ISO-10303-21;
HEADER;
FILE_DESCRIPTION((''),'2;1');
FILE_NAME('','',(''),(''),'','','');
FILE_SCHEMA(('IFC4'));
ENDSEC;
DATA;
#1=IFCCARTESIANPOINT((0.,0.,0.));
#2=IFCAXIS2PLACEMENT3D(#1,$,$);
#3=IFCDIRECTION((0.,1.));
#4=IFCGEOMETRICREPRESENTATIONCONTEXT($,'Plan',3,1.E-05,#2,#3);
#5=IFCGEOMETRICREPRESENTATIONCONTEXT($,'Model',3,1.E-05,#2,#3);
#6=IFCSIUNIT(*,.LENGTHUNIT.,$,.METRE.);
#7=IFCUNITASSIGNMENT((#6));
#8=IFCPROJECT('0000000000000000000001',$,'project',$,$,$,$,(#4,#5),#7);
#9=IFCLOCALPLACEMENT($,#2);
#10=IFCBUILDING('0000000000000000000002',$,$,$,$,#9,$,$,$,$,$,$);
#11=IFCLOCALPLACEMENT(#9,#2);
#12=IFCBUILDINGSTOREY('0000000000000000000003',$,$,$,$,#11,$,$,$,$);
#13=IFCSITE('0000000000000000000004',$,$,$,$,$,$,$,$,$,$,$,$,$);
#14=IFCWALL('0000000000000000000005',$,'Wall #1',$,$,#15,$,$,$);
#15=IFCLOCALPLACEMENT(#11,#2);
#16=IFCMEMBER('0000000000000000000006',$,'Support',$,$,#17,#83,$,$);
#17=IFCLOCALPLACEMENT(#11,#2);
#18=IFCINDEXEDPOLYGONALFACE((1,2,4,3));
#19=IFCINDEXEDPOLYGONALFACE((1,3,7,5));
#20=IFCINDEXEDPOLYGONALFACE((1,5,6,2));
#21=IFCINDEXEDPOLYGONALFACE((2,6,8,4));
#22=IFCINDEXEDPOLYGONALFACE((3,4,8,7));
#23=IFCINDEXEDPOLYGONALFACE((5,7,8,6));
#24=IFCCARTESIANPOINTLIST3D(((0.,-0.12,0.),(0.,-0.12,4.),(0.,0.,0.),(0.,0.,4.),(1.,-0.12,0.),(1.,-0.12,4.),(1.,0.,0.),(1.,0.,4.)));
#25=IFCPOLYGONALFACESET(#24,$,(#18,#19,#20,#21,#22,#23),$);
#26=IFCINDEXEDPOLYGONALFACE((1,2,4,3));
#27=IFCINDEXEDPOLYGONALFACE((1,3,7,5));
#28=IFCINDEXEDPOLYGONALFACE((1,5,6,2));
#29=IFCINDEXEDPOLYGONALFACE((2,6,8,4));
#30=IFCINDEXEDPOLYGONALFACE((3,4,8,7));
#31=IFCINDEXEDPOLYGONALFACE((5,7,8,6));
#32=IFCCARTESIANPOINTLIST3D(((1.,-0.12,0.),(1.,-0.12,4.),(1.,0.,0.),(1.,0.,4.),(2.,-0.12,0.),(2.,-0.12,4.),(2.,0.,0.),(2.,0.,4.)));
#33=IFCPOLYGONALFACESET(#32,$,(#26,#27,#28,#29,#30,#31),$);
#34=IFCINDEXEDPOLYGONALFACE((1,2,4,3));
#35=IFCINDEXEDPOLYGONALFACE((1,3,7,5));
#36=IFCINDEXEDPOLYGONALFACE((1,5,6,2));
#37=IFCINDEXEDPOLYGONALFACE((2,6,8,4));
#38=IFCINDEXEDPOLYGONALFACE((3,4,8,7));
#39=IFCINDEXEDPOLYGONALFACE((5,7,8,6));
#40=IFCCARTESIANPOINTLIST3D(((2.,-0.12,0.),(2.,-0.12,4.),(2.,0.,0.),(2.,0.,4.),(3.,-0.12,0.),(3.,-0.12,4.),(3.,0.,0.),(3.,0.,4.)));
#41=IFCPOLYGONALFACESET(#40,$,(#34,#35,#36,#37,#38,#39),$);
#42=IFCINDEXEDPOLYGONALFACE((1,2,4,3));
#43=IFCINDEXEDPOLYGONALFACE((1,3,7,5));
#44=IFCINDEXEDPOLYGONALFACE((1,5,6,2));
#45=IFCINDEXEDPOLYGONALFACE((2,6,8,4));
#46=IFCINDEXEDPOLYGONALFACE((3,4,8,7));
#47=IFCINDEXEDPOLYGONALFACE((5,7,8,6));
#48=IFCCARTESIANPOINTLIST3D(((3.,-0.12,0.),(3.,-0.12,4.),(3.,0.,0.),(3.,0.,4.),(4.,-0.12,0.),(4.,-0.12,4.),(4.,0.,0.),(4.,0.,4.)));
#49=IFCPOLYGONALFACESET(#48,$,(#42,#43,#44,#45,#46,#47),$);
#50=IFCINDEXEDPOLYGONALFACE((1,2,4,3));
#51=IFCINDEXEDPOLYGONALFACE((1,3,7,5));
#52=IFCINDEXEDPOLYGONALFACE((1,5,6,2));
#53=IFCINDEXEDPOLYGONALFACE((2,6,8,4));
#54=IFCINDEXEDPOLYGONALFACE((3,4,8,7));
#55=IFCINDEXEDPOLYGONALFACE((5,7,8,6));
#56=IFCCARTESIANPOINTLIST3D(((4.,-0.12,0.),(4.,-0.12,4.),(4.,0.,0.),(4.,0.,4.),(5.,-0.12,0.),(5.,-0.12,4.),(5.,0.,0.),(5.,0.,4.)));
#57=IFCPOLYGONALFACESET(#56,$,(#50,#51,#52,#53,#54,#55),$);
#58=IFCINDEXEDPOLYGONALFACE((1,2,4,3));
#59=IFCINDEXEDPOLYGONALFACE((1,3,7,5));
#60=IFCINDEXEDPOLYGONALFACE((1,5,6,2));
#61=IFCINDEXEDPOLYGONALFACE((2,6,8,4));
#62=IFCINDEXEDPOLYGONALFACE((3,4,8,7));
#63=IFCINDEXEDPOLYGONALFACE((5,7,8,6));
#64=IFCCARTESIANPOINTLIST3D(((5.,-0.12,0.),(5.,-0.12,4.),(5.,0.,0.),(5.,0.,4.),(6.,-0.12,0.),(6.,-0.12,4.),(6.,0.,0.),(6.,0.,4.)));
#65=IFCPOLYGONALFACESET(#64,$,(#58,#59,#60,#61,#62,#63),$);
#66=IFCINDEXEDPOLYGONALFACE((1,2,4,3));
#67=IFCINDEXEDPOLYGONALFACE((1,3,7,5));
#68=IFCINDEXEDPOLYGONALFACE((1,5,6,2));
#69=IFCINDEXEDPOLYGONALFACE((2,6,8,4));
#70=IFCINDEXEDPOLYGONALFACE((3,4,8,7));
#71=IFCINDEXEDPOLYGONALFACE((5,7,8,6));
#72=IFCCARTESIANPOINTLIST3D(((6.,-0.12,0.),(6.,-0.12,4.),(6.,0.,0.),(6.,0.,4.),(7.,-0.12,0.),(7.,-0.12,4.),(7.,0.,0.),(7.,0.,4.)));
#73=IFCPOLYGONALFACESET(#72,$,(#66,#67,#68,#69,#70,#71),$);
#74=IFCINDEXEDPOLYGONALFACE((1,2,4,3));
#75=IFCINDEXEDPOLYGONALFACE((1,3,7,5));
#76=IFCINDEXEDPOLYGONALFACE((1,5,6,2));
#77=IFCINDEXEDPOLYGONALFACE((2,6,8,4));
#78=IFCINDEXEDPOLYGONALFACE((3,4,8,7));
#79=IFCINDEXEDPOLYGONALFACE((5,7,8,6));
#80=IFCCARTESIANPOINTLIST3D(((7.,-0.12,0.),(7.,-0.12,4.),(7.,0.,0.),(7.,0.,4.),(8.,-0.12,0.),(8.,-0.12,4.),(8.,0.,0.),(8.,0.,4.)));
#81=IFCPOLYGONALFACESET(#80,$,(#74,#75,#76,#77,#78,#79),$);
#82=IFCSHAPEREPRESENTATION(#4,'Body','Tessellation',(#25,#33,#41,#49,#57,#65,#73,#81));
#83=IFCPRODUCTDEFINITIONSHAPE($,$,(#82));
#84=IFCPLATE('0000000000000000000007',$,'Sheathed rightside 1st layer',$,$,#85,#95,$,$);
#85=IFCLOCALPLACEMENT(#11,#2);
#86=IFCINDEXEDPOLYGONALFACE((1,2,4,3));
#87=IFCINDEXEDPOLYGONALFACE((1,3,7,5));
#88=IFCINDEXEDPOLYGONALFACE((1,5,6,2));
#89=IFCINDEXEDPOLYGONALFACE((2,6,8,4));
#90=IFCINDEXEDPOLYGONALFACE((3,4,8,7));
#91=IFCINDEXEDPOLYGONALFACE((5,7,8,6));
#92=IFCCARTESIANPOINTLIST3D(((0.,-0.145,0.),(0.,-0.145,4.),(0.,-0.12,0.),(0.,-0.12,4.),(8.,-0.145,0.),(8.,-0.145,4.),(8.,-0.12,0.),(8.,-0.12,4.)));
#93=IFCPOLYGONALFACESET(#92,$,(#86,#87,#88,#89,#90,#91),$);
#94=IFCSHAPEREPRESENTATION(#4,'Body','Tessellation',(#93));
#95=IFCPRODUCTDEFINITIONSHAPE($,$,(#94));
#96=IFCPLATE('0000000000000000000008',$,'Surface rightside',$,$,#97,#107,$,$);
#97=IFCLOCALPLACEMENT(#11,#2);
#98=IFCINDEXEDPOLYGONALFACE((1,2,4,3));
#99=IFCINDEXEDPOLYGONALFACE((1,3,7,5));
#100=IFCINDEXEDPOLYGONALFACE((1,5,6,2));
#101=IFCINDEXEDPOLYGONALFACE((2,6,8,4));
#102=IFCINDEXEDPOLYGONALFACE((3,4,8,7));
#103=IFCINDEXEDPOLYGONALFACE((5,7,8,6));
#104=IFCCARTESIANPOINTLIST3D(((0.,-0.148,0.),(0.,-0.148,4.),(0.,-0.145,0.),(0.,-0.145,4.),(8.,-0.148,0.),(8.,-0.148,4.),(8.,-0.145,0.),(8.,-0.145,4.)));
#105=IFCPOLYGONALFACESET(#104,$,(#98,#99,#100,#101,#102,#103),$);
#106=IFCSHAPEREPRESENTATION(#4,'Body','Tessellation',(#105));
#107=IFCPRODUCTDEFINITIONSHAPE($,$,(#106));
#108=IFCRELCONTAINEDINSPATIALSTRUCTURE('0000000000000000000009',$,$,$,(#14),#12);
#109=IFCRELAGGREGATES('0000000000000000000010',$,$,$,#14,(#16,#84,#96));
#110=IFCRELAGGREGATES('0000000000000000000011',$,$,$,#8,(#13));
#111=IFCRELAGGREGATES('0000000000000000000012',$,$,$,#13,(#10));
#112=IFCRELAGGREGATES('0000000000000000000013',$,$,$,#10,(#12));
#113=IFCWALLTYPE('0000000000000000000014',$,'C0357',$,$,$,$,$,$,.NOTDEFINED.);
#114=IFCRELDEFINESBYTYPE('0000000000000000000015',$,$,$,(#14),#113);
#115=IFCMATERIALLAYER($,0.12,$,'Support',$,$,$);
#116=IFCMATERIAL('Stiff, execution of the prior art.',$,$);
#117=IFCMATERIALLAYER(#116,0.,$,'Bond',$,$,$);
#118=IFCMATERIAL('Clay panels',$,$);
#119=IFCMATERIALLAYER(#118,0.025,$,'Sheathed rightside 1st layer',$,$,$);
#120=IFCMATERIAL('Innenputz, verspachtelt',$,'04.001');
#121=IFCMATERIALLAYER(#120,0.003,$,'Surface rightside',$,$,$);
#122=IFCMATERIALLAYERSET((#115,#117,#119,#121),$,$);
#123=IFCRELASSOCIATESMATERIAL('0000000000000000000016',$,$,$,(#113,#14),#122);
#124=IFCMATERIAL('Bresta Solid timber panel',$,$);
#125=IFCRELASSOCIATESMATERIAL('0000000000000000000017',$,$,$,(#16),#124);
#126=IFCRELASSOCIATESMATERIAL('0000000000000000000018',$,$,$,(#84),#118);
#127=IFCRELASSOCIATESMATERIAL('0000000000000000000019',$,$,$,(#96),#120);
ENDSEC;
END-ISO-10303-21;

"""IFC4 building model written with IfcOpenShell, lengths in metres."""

from ifc_helpers import new_model, si_unit, direction, frame, frame_2d, origin, place, context, project, spatial, rectangle, extrude, material, layer, layer_set, type_object, element, aggregate, save


model = new_model("IFC4")

# Units and contexts
plan_context = context("Plan", 3, precision=1e-05, world=origin(), true_north=direction((0.0, 1.0)))
model_context = context("Model", 3, precision=1e-05, world=origin(), true_north=direction((0.0, 1.0)))
ifc_project = project(units=[si_unit("LENGTHUNIT", "METRE")], contexts=[plan_context, model_context])

# Site, building, storey
site = spatial("IfcSite", under=ifc_project)
building_placement = place(None, origin())
building = spatial("IfcBuilding", under=site, at=building_placement)
storey_placement = place(building_placement, origin())
storey = spatial("IfcBuildingStorey", under=building, at=storey_placement)

# Wall, member, plates
ifc_layer_1 = layer(None, 0.12, Name="Support")
ifc_material_1 = material(Name="Stiff, execution of the prior art.")
ifc_layer_2 = layer(ifc_material_1, 0.0, Name="Bond")
ifc_material_2 = material(Name="Clay panels")
ifc_layer_3 = layer(ifc_material_2, 0.025, Name="Sheathed rightside 1st layer")
ifc_material_3 = material(Name="Innenputz, verspachtelt", Category="04.001")
ifc_layer_4 = layer(ifc_material_3, 0.003, Name="Surface rightside")
ifc_layer_set = layer_set([ifc_layer_1, ifc_layer_2, ifc_layer_3, ifc_layer_4])
wall_type = type_object("IfcWallType", Name="C0357", PredefinedType="NOTDEFINED", material=ifc_layer_set)
wall_placement = place(None, frame((0.0, 0.0, 0.0), z_axis=(0.0, -1.0, 0.0), x_axis=(1.0, 0.0, 0.0)))
wall = element("IfcWall", 1, at=wall_placement, inside=storey, type_object=wall_type, material=ifc_layer_set, Name="Wall #1")
ifc_material_4 = material(Name="Bresta Solid timber panel")
member_placement = place(wall_placement, origin())
member = element("IfcMember", 2, at=member_placement, material=ifc_material_4, Name="Support", context=plan_context, shape_type="SweptSolid", body=[
    extrude(rectangle(XDim=1.0, YDim=0.12, at=frame_2d((0.5, 0.06), x_axis=(1.0, 0.0))), frame((0.0, 4.0, 0.0), z_axis=(0.0, -1.0, 0.0), x_axis=(1.0, 0.0, 0.0)), (0.0, 0.0, 1.0), 4.0),
    extrude(rectangle(XDim=1.0, YDim=0.12, at=frame_2d((0.5, 0.06), x_axis=(1.0, 0.0))), frame((1.0, 4.0, 0.0), z_axis=(0.0, -1.0, 0.0), x_axis=(1.0, 0.0, 0.0)), (0.0, 0.0, 1.0), 4.0),
    extrude(rectangle(XDim=1.0, YDim=0.12, at=frame_2d((0.5, 0.06), x_axis=(1.0, 0.0))), frame((2.0, 4.0, 0.0), z_axis=(0.0, -1.0, 0.0), x_axis=(1.0, 0.0, 0.0)), (0.0, 0.0, 1.0), 4.0),
    extrude(rectangle(XDim=1.0, YDim=0.12, at=frame_2d((0.5, 0.06), x_axis=(1.0, 0.0))), frame((3.0, 4.0, 0.0), z_axis=(0.0, -1.0, 0.0), x_axis=(1.0, 0.0, 0.0)), (0.0, 0.0, 1.0), 4.0),
    extrude(rectangle(XDim=1.0, YDim=0.12, at=frame_2d((0.5, 0.06), x_axis=(1.0, 0.0))), frame((4.0, 4.0, 0.0), z_axis=(0.0, -1.0, 0.0), x_axis=(1.0, 0.0, 0.0)), (0.0, 0.0, 1.0), 4.0),
    extrude(rectangle(XDim=1.0, YDim=0.12, at=frame_2d((0.5, 0.06), x_axis=(1.0, 0.0))), frame((5.0, 4.0, 0.0), z_axis=(0.0, -1.0, 0.0), x_axis=(1.0, 0.0, 0.0)), (0.0, 0.0, 1.0), 4.0),
    extrude(rectangle(XDim=1.0, YDim=0.12, at=frame_2d((0.5, 0.06), x_axis=(1.0, 0.0))), frame((6.0, 4.0, 0.0), z_axis=(0.0, -1.0, 0.0), x_axis=(1.0, 0.0, 0.0)), (0.0, 0.0, 1.0), 4.0),
    extrude(rectangle(XDim=1.0, YDim=0.12, at=frame_2d((0.5, 0.06), x_axis=(1.0, 0.0))), frame((7.0, 4.0, 0.0), z_axis=(0.0, -1.0, 0.0), x_axis=(1.0, 0.0, 0.0)), (0.0, 0.0, 1.0), 4.0),
])
plate_1_placement = place(wall_placement, origin())
plate_1 = element("IfcPlate", 3, at=plate_1_placement, material=ifc_material_2, Name="Sheathed rightside 1st layer", context=plan_context, shape_type="SweptSolid", body=[
    extrude(rectangle(XDim=8.0, YDim=4.0, at=frame_2d((4.0, 2.0), x_axis=(1.0, 0.0))), frame((0.0, 0.0, 0.12), z_axis=(0.0, 0.0, 1.0), x_axis=(1.0, 0.0, 0.0)), (0.0, 0.0, 1.0), 0.025),
])
plate_2_placement = place(wall_placement, origin())
plate_2 = element("IfcPlate", 4, at=plate_2_placement, material=ifc_material_3, Name="Surface rightside", context=plan_context, shape_type="SweptSolid", body=[
    extrude(rectangle(XDim=8.0, YDim=4.0, at=frame_2d((4.0, 2.0), x_axis=(1.0, 0.0))), frame((0.0, 0.0, 0.145), z_axis=(0.0, 0.0, 1.0), x_axis=(1.0, 0.0, 0.0)), (0.0, 0.0, 1.0), 0.003),
])
aggregate(wall, [member, plate_1, plate_2])

save(model, "model.ifc")
